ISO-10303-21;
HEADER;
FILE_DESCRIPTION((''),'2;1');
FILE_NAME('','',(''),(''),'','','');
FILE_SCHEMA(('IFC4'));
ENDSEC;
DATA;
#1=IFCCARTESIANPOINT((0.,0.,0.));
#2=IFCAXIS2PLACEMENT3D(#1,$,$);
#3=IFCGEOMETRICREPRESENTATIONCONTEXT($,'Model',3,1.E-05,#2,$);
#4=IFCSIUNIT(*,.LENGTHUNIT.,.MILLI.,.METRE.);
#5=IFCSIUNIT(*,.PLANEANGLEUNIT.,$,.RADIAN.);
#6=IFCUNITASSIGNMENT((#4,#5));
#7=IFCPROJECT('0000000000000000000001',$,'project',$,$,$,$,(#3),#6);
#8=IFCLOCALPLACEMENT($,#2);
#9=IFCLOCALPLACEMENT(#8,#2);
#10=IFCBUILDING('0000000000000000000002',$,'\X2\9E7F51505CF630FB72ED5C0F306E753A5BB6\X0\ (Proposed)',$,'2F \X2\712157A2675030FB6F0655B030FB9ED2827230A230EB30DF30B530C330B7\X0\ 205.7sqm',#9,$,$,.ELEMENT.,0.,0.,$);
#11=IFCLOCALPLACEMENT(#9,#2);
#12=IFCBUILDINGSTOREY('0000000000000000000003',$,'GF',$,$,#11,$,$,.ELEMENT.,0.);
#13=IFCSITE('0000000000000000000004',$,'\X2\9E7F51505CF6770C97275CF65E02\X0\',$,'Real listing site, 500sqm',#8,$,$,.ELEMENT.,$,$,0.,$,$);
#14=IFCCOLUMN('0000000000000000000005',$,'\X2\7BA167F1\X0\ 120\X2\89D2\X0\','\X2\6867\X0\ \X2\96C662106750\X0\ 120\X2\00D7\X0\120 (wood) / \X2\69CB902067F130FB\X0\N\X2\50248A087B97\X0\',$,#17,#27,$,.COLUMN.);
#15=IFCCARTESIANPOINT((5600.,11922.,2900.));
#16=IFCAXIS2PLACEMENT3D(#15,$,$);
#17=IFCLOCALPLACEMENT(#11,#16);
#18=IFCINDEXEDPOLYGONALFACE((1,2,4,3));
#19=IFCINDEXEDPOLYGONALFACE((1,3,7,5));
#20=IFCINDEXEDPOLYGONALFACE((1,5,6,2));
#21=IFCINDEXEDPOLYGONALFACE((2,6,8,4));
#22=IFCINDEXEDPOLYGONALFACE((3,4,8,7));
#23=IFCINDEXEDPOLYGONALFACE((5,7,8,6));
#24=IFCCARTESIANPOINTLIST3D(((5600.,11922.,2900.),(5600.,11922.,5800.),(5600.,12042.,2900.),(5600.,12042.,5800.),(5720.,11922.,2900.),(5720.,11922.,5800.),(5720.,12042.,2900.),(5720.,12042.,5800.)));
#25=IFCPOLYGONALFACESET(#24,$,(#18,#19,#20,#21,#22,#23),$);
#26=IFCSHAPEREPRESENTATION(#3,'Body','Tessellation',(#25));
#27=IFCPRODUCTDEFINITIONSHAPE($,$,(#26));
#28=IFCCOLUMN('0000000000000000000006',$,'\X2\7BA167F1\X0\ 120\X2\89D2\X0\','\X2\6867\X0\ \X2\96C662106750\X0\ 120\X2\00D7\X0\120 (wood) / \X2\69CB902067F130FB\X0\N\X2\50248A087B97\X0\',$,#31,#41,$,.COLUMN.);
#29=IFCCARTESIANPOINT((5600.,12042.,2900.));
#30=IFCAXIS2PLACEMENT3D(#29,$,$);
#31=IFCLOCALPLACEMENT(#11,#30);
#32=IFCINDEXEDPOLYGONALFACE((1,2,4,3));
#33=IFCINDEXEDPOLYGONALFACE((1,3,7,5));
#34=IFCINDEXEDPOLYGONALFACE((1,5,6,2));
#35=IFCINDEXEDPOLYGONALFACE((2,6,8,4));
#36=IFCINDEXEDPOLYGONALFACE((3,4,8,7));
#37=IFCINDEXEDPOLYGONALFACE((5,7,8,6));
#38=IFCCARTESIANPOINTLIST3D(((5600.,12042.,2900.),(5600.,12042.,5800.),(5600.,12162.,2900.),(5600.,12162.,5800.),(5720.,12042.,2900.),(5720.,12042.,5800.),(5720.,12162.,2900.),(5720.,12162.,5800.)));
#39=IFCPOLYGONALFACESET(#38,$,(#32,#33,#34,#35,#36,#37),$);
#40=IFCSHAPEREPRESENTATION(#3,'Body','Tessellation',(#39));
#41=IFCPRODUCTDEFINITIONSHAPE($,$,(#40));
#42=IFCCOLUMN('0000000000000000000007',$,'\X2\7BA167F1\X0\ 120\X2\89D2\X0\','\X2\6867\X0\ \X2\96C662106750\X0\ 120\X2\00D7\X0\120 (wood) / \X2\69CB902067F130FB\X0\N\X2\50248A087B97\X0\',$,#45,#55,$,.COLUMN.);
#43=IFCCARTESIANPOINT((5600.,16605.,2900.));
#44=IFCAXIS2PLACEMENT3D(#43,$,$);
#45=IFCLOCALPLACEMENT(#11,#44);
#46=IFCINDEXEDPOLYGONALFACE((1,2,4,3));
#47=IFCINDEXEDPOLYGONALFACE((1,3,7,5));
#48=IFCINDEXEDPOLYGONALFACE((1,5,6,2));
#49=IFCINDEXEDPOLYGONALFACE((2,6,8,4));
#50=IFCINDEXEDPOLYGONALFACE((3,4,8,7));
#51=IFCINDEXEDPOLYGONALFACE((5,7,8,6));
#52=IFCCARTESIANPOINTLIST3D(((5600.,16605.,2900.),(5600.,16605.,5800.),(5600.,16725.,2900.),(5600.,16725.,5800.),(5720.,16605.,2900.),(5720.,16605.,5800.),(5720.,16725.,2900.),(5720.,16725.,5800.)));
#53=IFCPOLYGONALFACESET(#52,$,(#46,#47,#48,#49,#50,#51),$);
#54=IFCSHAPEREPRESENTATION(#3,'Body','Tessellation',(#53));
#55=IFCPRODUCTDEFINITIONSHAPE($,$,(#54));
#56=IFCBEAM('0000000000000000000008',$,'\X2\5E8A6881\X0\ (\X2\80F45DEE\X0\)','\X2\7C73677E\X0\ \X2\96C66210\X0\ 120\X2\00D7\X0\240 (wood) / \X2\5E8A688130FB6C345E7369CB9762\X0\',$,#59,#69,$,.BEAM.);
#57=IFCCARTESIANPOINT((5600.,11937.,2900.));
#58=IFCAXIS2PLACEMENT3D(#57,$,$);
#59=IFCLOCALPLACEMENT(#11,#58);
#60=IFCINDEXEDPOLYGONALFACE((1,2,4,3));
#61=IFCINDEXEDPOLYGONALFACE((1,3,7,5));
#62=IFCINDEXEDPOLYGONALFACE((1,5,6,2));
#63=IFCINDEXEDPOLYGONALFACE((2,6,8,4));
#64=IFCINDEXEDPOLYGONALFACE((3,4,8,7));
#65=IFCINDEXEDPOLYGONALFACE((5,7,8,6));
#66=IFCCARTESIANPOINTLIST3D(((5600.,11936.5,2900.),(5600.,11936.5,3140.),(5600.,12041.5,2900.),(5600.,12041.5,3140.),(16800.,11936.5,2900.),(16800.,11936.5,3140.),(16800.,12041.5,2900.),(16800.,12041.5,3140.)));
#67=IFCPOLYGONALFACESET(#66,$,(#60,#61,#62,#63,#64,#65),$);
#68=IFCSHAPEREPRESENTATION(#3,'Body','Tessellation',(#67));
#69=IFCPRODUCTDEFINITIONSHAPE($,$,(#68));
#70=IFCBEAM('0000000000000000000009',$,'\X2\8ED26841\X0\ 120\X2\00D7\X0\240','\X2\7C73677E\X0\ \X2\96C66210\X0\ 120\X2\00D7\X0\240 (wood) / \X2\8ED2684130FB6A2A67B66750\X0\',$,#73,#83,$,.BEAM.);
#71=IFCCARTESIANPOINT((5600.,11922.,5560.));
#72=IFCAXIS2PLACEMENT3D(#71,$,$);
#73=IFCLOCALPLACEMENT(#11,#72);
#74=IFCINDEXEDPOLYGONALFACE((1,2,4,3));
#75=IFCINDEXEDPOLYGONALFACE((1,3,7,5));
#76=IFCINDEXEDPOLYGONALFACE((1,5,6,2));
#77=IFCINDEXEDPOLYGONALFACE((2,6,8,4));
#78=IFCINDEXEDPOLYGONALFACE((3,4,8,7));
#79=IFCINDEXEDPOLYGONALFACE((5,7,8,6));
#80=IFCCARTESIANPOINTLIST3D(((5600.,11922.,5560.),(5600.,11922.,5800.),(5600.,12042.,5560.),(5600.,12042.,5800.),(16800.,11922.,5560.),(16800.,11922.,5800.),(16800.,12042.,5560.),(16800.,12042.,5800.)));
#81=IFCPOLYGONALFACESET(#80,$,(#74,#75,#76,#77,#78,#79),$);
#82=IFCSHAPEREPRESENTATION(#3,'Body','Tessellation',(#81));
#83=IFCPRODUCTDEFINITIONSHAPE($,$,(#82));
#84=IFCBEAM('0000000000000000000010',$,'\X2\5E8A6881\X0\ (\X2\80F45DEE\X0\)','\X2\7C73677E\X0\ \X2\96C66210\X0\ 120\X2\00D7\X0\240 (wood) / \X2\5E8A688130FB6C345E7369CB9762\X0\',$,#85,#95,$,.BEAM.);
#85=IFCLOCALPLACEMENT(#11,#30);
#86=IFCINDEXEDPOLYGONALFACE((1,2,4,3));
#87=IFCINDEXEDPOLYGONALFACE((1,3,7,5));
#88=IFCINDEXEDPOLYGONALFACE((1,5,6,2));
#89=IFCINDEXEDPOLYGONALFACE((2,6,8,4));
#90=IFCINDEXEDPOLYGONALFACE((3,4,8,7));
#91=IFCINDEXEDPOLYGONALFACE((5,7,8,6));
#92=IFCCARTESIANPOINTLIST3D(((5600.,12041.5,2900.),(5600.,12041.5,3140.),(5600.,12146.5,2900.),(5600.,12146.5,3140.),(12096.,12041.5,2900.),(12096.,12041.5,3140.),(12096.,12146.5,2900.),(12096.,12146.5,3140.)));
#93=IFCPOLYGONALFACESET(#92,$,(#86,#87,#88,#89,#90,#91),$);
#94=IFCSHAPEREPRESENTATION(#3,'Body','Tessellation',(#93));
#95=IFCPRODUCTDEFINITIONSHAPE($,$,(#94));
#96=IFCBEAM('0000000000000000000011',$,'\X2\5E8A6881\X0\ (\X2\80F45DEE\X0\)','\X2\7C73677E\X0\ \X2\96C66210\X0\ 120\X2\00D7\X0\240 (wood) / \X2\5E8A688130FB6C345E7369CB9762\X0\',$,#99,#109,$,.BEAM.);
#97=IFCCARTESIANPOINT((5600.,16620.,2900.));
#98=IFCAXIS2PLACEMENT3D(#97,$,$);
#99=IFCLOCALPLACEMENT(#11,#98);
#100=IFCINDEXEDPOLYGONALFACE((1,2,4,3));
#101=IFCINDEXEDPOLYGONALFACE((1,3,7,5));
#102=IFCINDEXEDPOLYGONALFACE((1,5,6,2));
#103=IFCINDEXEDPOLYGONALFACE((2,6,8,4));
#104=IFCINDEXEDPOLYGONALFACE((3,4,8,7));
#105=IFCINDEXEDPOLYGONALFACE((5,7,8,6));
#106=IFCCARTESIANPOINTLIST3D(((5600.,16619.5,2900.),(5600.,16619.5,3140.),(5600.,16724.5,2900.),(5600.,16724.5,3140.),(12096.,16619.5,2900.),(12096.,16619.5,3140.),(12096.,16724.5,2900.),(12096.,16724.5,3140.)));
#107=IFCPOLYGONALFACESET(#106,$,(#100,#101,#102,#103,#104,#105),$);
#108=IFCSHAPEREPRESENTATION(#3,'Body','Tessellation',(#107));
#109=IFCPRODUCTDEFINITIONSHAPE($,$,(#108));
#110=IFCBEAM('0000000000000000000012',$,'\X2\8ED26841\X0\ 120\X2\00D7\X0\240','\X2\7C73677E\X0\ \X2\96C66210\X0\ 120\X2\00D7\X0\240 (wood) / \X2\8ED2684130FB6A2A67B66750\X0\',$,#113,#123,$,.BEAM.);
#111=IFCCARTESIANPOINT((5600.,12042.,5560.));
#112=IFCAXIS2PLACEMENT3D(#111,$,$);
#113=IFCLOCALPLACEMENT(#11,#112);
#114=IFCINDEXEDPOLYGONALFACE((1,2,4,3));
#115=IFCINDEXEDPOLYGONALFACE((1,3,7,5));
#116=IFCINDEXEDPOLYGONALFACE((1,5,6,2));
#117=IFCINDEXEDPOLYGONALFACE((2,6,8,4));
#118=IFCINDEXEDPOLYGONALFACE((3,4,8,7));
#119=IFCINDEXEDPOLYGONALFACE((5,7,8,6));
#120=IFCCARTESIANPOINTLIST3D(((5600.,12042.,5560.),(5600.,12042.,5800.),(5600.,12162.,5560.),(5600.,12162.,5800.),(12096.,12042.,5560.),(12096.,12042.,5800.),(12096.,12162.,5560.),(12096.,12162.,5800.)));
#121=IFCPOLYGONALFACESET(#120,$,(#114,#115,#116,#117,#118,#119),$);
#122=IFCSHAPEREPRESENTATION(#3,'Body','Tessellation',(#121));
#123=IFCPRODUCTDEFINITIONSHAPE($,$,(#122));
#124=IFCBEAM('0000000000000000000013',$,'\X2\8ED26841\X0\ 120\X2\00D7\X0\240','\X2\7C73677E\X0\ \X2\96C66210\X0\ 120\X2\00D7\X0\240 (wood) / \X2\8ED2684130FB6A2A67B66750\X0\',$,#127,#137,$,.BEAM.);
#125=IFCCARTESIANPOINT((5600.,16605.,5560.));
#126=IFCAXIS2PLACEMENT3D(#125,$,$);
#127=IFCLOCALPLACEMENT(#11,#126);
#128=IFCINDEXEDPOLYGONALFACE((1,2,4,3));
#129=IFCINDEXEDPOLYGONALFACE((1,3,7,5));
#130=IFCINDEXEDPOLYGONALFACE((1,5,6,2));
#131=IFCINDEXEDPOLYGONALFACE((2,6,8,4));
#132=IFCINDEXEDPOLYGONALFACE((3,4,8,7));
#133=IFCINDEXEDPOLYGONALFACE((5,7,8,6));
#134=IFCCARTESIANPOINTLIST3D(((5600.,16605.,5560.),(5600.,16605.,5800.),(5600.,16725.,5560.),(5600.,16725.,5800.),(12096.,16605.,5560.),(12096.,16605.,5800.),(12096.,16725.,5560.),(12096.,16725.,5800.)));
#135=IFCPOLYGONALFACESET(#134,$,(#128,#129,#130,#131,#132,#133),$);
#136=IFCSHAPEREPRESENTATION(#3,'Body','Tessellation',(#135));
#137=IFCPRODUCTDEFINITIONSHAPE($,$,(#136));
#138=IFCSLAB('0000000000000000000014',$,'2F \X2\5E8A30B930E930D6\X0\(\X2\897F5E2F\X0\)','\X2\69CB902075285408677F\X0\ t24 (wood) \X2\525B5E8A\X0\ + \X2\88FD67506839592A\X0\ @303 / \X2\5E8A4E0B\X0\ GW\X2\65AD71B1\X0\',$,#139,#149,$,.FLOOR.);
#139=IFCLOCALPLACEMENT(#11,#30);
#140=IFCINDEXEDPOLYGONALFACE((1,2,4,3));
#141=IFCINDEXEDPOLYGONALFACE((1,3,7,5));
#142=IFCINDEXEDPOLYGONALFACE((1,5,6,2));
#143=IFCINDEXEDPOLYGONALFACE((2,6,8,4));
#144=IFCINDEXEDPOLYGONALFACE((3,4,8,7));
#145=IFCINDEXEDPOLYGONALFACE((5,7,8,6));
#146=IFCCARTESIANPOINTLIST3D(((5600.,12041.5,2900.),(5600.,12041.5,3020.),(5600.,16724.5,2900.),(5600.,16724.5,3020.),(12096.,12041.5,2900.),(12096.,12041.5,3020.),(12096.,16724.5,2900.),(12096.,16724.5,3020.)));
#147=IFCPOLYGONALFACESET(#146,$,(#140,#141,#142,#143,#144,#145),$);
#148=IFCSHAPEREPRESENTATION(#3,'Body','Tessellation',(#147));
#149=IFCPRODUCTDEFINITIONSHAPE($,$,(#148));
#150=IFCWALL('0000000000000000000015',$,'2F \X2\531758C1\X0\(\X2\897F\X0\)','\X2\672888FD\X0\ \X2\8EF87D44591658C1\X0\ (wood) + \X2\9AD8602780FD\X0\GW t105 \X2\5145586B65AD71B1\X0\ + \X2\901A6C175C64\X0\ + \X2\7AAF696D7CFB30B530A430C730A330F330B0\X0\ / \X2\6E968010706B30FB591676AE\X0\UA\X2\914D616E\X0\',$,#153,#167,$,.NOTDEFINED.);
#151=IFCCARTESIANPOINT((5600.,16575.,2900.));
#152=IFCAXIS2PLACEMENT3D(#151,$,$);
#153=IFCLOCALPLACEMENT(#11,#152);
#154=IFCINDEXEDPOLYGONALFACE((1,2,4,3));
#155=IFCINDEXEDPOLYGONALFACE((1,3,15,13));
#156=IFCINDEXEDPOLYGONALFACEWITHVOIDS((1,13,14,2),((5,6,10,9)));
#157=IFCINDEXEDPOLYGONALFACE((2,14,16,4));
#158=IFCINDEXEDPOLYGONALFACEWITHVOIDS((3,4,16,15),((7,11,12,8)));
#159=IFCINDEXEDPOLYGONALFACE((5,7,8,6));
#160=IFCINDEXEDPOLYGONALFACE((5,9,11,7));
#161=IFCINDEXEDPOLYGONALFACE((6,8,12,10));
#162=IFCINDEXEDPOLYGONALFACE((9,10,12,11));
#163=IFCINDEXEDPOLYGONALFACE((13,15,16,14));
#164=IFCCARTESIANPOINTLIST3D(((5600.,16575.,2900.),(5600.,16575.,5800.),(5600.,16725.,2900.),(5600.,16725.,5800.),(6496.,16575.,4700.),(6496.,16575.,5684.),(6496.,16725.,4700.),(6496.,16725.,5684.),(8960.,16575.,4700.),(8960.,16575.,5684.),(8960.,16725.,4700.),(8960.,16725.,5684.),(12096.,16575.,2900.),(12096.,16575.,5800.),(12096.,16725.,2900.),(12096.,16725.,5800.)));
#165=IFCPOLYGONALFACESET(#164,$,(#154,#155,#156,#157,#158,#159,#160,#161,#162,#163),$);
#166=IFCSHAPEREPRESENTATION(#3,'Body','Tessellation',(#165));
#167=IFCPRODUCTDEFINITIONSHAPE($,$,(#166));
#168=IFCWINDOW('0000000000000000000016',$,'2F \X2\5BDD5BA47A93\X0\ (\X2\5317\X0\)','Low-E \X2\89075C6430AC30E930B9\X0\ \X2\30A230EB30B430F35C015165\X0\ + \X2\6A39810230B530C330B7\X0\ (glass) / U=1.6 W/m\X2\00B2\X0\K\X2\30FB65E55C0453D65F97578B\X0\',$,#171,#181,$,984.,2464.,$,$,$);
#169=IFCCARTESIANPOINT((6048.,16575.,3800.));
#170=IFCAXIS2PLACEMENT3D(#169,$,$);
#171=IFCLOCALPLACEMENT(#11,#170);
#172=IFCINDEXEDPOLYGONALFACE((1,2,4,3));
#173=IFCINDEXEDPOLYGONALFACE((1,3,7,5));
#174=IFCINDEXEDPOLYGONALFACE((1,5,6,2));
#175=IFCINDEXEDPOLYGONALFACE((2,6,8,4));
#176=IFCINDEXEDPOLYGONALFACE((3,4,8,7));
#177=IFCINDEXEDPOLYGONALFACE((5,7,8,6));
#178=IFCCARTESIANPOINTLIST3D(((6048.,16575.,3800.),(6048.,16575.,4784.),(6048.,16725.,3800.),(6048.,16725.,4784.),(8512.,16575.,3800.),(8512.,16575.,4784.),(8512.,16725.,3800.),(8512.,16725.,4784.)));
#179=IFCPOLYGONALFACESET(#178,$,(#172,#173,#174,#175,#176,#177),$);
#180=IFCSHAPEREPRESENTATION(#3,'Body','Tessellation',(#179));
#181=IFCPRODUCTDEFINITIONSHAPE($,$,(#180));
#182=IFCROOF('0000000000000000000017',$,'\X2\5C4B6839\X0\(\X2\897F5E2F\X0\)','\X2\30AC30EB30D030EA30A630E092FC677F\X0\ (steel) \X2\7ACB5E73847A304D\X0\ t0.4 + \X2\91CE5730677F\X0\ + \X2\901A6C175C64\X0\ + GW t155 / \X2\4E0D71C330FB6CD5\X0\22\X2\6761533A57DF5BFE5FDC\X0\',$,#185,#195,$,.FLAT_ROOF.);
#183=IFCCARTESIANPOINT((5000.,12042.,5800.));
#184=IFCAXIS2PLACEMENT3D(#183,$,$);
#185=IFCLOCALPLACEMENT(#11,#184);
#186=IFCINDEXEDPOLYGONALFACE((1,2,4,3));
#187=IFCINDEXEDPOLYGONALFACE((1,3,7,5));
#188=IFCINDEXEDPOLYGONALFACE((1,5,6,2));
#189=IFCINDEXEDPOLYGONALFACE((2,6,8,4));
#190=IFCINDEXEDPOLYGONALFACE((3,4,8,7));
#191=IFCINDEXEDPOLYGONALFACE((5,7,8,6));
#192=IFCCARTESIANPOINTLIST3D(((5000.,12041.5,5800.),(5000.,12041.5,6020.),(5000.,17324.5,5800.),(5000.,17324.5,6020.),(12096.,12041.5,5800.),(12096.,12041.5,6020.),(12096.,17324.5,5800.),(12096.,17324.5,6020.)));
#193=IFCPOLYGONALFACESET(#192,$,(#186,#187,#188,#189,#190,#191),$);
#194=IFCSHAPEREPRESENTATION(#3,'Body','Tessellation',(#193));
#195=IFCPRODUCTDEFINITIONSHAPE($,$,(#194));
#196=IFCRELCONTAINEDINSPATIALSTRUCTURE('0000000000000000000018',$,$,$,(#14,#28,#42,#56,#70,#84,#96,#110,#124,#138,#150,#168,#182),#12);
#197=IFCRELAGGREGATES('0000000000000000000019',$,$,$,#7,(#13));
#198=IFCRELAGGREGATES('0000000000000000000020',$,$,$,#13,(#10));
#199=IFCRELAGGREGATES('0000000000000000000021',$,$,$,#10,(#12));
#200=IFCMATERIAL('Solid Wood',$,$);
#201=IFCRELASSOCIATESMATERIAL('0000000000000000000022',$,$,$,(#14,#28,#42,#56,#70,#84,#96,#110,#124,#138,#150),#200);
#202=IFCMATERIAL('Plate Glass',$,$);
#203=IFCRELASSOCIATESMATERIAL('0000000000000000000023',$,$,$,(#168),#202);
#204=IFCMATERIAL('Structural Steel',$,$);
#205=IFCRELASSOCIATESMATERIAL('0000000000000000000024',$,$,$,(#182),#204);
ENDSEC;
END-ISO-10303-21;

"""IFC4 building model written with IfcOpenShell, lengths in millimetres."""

from ifc_helpers import new_model, si_unit, frame, frame_2d, origin, place, context, project, spatial, rectangle, extrude, material, element, fill, save


model = new_model("IFC4")

# Units and contexts
model_context = context("Model", 3, precision=1e-05, world=origin())
ifc_project = project(units=[si_unit("LENGTHUNIT", "METRE", prefix="MILLI"), si_unit("PLANEANGLEUNIT", "RADIAN")], contexts=[model_context])

# Site, building, storey
site_placement = place(None, origin())
site = spatial("IfcSite", under=ifc_project, at=site_placement, Name="鹿児島県霧島市", ObjectType="Real listing site, 500sqm", CompositionType="ELEMENT", RefElevation=0.0)
building_placement = place(site_placement, origin())
building = spatial("IfcBuilding", under=site, at=building_placement, Name="鹿児島・狭小の町家 (Proposed)", ObjectType="2F 無垢材・漆喰・黒色アルミサッシ 205.7sqm", CompositionType="ELEMENT", ElevationOfRefHeight=0.0, ElevationOfTerrain=0.0)
storey_placement = place(building_placement, origin())
storey = spatial("IfcBuildingStorey", under=building, at=storey_placement, Name="GF", CompositionType="ELEMENT", Elevation=0.0)

# Columns
ifc_material_1 = material(Name="Solid Wood")
column_1_placement = place(storey_placement, frame((5600.0, 11922.0, 2900.0)))
element("IfcColumn", 1, at=column_1_placement, inside=storey, material=ifc_material_1, Name="管柱 120角", Description="桧 集成材 120×120 (wood) / 構造柱・N値計算", PredefinedType="COLUMN", context=model_context, shape_type="SweptSolid", body=[
    extrude(rectangle(XDim=120.0, YDim=120.0, at=frame_2d((60.0, 60.0))), frame((5600.0, 11922.0, 2900.0)), (0.0, 0.0, 1.0), 2900.0),
])
column_2_placement = place(storey_placement, frame((5600.0, 12042.0, 2900.0)))
element("IfcColumn", 2, at=column_2_placement, inside=storey, material=ifc_material_1, Name="管柱 120角", Description="桧 集成材 120×120 (wood) / 構造柱・N値計算", PredefinedType="COLUMN", context=model_context, shape_type="SweptSolid", body=[
    extrude(rectangle(XDim=120.0, YDim=120.0, at=frame_2d((60.0, 60.0))), frame((5600.0, 12042.0, 2900.0)), (0.0, 0.0, 1.0), 2900.0),
])
column_3_placement = place(storey_placement, frame((5600.0, 16605.0, 2900.0)))
element("IfcColumn", 3, at=column_3_placement, inside=storey, material=ifc_material_1, Name="管柱 120角", Description="桧 集成材 120×120 (wood) / 構造柱・N値計算", PredefinedType="COLUMN", context=model_context, shape_type="SweptSolid", body=[
    extrude(rectangle(XDim=120.0, YDim=120.0, at=frame_2d((60.0, 60.0))), frame((5600.0, 16605.0, 2900.0)), (0.0, 0.0, 1.0), 2900.0),
])

# Beams
beam_1_placement = place(storey_placement, frame((5600.0, 11937.0, 2900.0)))
element("IfcBeam", 4, at=beam_1_placement, inside=storey, material=ifc_material_1, Name="床梁 (胴差)", Description="米松 集成 120×240 (wood) / 床梁・水平構面", PredefinedType="BEAM", context=model_context, shape_type="SweptSolid", body=[
    extrude(rectangle(XDim=11200.0, YDim=105.0, at=frame_2d((5600.0, 52.0))), frame((5600.0, 11937.0, 2900.0)), (0.0, 0.0, 1.0), 240.0),
])
beam_2_placement = place(storey_placement, frame((5600.0, 11922.0, 5560.0)))
element("IfcBeam", 5, at=beam_2_placement, inside=storey, material=ifc_material_1, Name="軒桁 120×240", Description="米松 集成 120×240 (wood) / 軒桁・横架材", PredefinedType="BEAM", context=model_context, shape_type="SweptSolid", body=[
    extrude(rectangle(XDim=11200.0, YDim=120.0, at=frame_2d((5600.0, 60.0))), frame((5600.0, 11922.0, 5560.0)), (0.0, 0.0, 1.0), 240.0),
])
beam_3_placement = place(storey_placement, frame((5600.0, 12042.0, 2900.0)))
element("IfcBeam", 6, at=beam_3_placement, inside=storey, material=ifc_material_1, Name="床梁 (胴差)", Description="米松 集成 120×240 (wood) / 床梁・水平構面", PredefinedType="BEAM", context=model_context, shape_type="SweptSolid", body=[
    extrude(rectangle(XDim=6496.0, YDim=105.0, at=frame_2d((3248.0, 52.0))), frame((5600.0, 12042.0, 2900.0)), (0.0, 0.0, 1.0), 240.0),
])
beam_4_placement = place(storey_placement, frame((5600.0, 16620.0, 2900.0)))
element("IfcBeam", 7, at=beam_4_placement, inside=storey, material=ifc_material_1, Name="床梁 (胴差)", Description="米松 集成 120×240 (wood) / 床梁・水平構面", PredefinedType="BEAM", context=model_context, shape_type="SweptSolid", body=[
    extrude(rectangle(XDim=6496.0, YDim=105.0, at=frame_2d((3248.0, 52.0))), frame((5600.0, 16620.0, 2900.0)), (0.0, 0.0, 1.0), 240.0),
])
beam_5_placement = place(storey_placement, frame((5600.0, 12042.0, 5560.0)))
element("IfcBeam", 8, at=beam_5_placement, inside=storey, material=ifc_material_1, Name="軒桁 120×240", Description="米松 集成 120×240 (wood) / 軒桁・横架材", PredefinedType="BEAM", context=model_context, shape_type="SweptSolid", body=[
    extrude(rectangle(XDim=6496.0, YDim=120.0, at=frame_2d((3248.0, 60.0))), frame((5600.0, 12042.0, 5560.0)), (0.0, 0.0, 1.0), 240.0),
])
beam_6_placement = place(storey_placement, frame((5600.0, 16605.0, 5560.0)))
element("IfcBeam", 9, at=beam_6_placement, inside=storey, material=ifc_material_1, Name="軒桁 120×240", Description="米松 集成 120×240 (wood) / 軒桁・横架材", PredefinedType="BEAM", context=model_context, shape_type="SweptSolid", body=[
    extrude(rectangle(XDim=6496.0, YDim=120.0, at=frame_2d((3248.0, 60.0))), frame((5600.0, 16605.0, 5560.0)), (0.0, 0.0, 1.0), 240.0),
])

# Slab
slab_placement = place(storey_placement, frame((5600.0, 12042.0, 2900.0)))
element("IfcSlab", 10, at=slab_placement, inside=storey, material=ifc_material_1, Name="2F 床スラブ(西帯)", Description="構造用合板 t24 (wood) 剛床 + 製材根太 @303 / 床下 GW断熱", PredefinedType="FLOOR", context=model_context, shape_type="SweptSolid", body=[
    extrude(rectangle(XDim=6496.0, YDim=4683.0, at=frame_2d((3248.0, 2341.0))), frame((5600.0, 12042.0, 2900.0)), (0.0, 0.0, 1.0), 120.0),
])

# Wall, opening, window
wall_1_placement = place(storey_placement, frame((5600.0, 16575.0, 2900.0)))
wall_1 = element("IfcWall", 11, at=wall_1_placement, inside=storey, material=ifc_material_1, Name="2F 北壁(西)", Description="木製 軸組外壁 (wood) + 高性能GW t105 充填断熱 + 通気層 + 窯業系サイディング / 準耐火・外皮UA配慮", PredefinedType="NOTDEFINED", context=model_context, shape_type="SweptSolid", body=[
    extrude(rectangle(XDim=6496.0, YDim=150.0, at=frame_2d((3248.0, 75.0))), frame((5600.0, 16575.0, 2900.0)), (0.0, 0.0, 1.0), 2900.0),
])
opening_placement = place(storey_placement, frame((6048.0, 16575.0, 3800.0)))
opening = element("IfcOpeningElement", 12, at=opening_placement, cuts=wall_1, PredefinedType="NOTDEFINED", context=model_context, shape_type="SweptSolid", body=[
    extrude(rectangle(XDim=2464.0, YDim=150.0, at=frame_2d((1232.0, 75.0))), frame((6048.0, 16575.0, 3800.0)), (0.0, 0.0, 1.0), 984.0),
])
ifc_material_2 = material(Name="Plate Glass")
window_placement = place(storey_placement, frame((6048.0, 16575.0, 3800.0)))
window = element("IfcWindow", 13, at=window_placement, inside=storey, material=ifc_material_2, Name="2F 寝室窓 (北)", Description="Low-E 複層ガラス アルゴン封入 + 樹脂サッシ (glass) / U=1.6 W/m²K・日射取得型", OverallHeight=984.0, OverallWidth=2464.0, context=model_context, shape_type="SweptSolid", body=[
    extrude(rectangle(XDim=2464.0, YDim=150.0, at=frame_2d((1232.0, 75.0))), frame((6048.0, 16575.0, 3800.0)), (0.0, 0.0, 1.0), 984.0),
])
fill(opening, window)

# Roof
ifc_material_3 = material(Name="Structural Steel")
for number, where, name in (
    (14, (5000.0, 12042.0, 5800.0), "屋根(西帯)"),
):
    element("IfcRoof", number, at=place(storey_placement, frame(where)), inside=storey, material=ifc_material_3, Name=name, Description="ガルバリウム鋼板 (steel) 立平葺き t0.4 + 野地板 + 通気層 + GW t155 / 不燃・法22条区域対応", PredefinedType="FLAT_ROOF", context=model_context, shape_type="SweptSolid", body=[
        extrude(rectangle(XDim=7096.0, YDim=5283.0, at=frame_2d((3548.0, 2641.0))), frame((5000.0, 12042.0, 5800.0)), (0.0, 0.0, 1.0), 220.0),
    ])

save(model, "model.ifc")
